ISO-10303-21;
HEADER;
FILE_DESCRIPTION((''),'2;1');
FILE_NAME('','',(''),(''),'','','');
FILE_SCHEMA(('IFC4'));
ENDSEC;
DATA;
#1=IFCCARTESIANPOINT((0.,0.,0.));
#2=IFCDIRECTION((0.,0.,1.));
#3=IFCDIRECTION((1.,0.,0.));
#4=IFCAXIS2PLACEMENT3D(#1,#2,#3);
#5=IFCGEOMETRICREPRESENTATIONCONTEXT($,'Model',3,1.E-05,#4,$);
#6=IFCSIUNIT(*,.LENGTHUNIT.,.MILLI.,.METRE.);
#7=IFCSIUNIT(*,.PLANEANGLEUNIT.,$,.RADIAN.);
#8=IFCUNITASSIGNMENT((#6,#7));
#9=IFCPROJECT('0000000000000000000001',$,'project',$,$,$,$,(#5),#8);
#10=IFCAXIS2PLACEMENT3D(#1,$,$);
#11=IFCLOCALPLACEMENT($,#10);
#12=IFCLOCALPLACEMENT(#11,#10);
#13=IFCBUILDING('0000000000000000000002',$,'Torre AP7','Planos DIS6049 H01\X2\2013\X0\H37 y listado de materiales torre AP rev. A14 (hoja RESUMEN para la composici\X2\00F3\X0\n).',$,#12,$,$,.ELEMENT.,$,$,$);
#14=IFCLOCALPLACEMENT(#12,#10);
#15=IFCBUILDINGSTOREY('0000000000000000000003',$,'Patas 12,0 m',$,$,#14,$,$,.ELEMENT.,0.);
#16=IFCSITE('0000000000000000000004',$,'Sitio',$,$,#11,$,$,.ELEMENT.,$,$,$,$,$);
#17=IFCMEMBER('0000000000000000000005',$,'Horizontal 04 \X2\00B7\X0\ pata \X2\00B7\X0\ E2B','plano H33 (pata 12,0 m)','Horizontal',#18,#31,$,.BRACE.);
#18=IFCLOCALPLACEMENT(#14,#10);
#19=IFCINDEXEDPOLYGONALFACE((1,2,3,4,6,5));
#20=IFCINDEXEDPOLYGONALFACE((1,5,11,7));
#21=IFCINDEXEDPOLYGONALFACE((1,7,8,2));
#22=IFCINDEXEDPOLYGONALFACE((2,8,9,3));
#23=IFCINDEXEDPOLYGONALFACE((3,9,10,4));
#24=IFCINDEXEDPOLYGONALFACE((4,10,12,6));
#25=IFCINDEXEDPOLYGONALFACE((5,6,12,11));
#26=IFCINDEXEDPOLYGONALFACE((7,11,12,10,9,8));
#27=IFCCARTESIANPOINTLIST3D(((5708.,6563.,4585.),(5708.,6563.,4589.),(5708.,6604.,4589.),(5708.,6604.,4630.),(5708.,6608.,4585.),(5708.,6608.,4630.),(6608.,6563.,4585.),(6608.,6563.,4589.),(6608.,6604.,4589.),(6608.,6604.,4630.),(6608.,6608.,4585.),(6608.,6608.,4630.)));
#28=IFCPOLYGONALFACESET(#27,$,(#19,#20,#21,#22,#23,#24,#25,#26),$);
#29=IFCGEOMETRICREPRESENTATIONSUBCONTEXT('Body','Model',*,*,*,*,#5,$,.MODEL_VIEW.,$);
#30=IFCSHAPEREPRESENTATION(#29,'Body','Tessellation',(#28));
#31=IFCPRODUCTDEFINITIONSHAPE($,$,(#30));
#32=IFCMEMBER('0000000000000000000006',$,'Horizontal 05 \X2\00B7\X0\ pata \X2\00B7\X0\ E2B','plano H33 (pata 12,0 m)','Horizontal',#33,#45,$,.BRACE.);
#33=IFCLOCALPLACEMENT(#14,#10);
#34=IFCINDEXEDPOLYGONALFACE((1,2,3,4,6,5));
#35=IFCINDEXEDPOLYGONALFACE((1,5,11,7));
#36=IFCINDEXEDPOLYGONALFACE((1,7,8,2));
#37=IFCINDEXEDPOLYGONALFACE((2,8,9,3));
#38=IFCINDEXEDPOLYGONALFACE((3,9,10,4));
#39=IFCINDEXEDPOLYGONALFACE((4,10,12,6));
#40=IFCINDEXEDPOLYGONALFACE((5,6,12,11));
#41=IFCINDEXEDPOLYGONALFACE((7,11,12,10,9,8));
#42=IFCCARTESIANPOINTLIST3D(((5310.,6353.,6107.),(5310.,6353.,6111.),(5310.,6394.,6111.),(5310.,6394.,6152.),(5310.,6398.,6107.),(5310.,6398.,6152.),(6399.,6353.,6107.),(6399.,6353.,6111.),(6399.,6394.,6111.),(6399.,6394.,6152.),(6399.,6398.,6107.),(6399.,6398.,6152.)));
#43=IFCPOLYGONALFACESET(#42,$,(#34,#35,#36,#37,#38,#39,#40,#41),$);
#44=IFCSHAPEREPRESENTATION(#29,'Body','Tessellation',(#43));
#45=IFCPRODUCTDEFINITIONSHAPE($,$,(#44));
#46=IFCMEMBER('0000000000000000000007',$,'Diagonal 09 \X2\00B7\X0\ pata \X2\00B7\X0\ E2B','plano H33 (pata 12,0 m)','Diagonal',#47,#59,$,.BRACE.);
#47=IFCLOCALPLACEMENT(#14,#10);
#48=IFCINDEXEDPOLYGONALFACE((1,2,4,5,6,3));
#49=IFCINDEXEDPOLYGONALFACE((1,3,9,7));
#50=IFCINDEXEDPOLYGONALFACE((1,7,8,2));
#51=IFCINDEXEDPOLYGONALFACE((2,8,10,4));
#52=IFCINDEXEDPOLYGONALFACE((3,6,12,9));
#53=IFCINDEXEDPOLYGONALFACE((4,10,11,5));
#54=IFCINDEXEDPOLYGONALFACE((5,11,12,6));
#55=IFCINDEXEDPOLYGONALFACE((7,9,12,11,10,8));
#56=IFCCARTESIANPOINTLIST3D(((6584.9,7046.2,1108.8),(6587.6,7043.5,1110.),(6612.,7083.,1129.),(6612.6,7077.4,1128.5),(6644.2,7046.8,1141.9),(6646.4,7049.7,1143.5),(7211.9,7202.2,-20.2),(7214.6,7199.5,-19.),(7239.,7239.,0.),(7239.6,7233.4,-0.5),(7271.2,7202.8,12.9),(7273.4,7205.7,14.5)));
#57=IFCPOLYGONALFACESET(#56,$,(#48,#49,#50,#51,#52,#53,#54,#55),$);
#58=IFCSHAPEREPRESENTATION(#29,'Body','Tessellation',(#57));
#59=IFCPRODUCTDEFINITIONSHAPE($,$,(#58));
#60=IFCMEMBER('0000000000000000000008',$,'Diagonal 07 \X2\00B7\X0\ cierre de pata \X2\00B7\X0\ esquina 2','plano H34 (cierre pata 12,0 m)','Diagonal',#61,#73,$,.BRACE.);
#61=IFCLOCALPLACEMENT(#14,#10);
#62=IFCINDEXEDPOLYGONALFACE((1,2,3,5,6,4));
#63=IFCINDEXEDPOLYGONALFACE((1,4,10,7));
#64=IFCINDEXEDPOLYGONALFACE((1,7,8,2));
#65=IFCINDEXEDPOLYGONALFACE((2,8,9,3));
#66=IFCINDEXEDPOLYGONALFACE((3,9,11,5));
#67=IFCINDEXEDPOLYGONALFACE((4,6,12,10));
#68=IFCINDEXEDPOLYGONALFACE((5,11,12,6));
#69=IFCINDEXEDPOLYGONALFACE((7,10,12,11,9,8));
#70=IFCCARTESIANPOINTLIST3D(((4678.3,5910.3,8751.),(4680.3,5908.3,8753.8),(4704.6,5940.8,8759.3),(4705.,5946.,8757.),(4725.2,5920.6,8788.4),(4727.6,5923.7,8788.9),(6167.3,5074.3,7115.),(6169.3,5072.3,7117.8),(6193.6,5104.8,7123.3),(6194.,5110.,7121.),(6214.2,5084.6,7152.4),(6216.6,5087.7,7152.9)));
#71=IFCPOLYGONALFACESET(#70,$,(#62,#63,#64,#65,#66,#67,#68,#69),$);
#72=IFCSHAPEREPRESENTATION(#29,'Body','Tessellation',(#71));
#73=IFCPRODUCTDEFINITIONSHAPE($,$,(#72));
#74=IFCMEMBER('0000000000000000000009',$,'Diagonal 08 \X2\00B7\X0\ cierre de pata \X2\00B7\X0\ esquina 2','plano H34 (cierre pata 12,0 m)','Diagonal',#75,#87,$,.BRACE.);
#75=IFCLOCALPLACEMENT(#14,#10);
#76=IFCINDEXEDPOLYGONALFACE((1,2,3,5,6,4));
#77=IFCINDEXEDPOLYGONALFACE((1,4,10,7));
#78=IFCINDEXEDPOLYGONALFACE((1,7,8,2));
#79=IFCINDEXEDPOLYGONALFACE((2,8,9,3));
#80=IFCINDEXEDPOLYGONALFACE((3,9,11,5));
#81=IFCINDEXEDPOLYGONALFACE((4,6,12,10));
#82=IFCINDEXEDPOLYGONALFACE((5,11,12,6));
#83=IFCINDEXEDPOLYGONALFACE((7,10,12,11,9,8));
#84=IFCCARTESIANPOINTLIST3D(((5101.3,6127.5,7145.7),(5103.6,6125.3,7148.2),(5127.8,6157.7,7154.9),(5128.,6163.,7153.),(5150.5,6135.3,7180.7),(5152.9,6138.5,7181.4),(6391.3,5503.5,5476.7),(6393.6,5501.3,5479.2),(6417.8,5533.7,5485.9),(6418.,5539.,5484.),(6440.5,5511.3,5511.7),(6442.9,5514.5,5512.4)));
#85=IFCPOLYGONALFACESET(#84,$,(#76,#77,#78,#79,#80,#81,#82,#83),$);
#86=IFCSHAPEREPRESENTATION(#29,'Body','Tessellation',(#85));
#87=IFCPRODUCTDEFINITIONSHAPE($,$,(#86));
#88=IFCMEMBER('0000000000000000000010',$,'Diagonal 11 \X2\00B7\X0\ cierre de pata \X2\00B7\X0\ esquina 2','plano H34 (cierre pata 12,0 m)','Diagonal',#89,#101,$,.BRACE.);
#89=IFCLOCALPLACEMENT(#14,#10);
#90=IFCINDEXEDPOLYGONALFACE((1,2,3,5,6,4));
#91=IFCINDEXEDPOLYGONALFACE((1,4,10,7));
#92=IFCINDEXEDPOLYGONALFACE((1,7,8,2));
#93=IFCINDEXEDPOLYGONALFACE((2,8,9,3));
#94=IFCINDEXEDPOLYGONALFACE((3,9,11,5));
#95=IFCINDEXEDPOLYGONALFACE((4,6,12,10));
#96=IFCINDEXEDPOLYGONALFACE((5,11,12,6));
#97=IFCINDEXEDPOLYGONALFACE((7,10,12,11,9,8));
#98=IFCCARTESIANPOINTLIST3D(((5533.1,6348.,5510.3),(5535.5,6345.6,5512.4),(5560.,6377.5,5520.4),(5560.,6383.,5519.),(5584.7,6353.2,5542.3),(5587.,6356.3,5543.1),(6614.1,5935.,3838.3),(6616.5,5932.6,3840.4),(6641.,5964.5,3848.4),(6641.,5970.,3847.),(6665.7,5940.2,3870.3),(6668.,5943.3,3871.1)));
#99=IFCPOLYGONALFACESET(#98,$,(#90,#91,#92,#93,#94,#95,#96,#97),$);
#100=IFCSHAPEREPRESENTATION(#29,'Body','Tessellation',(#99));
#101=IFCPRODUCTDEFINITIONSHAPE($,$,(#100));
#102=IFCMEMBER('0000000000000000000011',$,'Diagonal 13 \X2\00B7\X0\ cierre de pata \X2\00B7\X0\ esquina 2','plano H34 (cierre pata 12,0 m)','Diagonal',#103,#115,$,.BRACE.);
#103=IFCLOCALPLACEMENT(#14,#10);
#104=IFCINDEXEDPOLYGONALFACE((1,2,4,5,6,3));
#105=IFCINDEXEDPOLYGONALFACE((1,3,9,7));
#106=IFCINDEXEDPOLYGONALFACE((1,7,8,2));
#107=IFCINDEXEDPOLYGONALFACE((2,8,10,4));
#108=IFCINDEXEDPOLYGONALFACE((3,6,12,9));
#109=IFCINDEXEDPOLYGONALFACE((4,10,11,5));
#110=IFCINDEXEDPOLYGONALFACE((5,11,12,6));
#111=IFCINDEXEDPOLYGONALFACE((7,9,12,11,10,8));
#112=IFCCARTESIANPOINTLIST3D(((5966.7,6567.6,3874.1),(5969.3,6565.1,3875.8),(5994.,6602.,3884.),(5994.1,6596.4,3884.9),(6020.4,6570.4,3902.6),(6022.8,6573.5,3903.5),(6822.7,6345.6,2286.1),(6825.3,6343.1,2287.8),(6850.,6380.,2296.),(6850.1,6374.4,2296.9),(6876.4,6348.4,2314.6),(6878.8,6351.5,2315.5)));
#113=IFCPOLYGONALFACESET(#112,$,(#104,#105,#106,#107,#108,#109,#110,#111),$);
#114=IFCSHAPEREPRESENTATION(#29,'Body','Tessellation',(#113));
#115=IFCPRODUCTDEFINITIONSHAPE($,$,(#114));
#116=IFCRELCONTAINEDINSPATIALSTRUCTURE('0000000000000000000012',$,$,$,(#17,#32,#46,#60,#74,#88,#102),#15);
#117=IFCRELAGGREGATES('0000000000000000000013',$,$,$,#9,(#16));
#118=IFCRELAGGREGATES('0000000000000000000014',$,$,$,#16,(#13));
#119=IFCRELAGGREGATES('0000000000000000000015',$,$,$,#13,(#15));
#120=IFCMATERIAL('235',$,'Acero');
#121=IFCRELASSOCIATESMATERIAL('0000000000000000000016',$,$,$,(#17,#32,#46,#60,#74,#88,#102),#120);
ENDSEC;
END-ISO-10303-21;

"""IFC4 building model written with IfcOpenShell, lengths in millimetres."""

from ifc_helpers import new_model, si_unit, frame, frame_2d, origin, origin_with_axes, place, context, subcontext, project, spatial, l_section, extrude, material, element, save


model = new_model("IFC4")

# Units and contexts
model_context = context("Model", 3, precision=1e-05, world=origin_with_axes())
body_context = subcontext(model_context, "Body", "Model", "MODEL_VIEW")
ifc_project = project(units=[si_unit("LENGTHUNIT", "METRE", prefix="MILLI"), si_unit("PLANEANGLEUNIT", "RADIAN")], contexts=[model_context])

# Site, building, storey
site_placement = place(None, origin())
site = spatial("IfcSite", under=ifc_project, at=site_placement, Name="Sitio", CompositionType="ELEMENT")
building_placement = place(site_placement, origin())
building = spatial("IfcBuilding", under=site, at=building_placement, Name="Torre AP7", Description="Planos DIS6049 H01–H37 y listado de materiales torre AP rev. A14 (hoja RESUMEN para la composición).", CompositionType="ELEMENT")
storey_placement = place(building_placement, origin())
storey = spatial("IfcBuildingStorey", under=building, at=storey_placement, Name="Patas 12,0 m", CompositionType="ELEMENT", Elevation=0.0)

# Members
ifc_material_1 = material(Name="235", Category="Acero")
member_1_placement = place(storey_placement, frame((6608.0, 6608.0, 4585.0), z_axis=(-1.0, 0.0, 0.0), x_axis=(0.0, -1.0, 0.0)))
element("IfcMember", 1, at=member_1_placement, inside=storey, material=ifc_material_1, Name="Horizontal 04 · pata · E2B", Description="plano H33 (pata 12,0 m)", ObjectType="Horizontal", PredefinedType="BRACE", context=body_context, shape_type="SweptSolid", body=[
    extrude(l_section(Depth=45.0, Width=45.0, Thickness=4.0, at=frame_2d((22.5, 22.5))), None, (0.0, 0.0, 1.0), 900.0),
])
member_2_placement = place(storey_placement, frame((6399.0, 6398.0, 6107.0), z_axis=(-1.0, 0.0, 0.0), x_axis=(0.0, -1.0, 0.0)))
element("IfcMember", 2, at=member_2_placement, inside=storey, material=ifc_material_1, Name="Horizontal 05 · pata · E2B", Description="plano H33 (pata 12,0 m)", ObjectType="Horizontal", PredefinedType="BRACE", context=body_context, shape_type="SweptSolid", body=[
    extrude(l_section(Depth=45.0, Width=45.0, Thickness=4.0, at=frame_2d((22.5, 22.5))), None, (0.0, 0.0, 1.0), 1089.0),
])
member_3_placement = place(storey_placement, frame((7239.0, 7239.0, 0.0), z_axis=(-0.482007, -0.119925, 0.867921), x_axis=(-0.542627, -0.73689, -0.403173)))
element("IfcMember", 3, at=member_3_placement, inside=storey, material=ifc_material_1, Name="Diagonal 09 · pata · E2B", Description="plano H33 (pata 12,0 m)", ObjectType="Diagonal", PredefinedType="BRACE", context=body_context, shape_type="SweptSolid", body=[
    extrude(l_section(Depth=50.0, Width=50.0, Thickness=4.0, at=frame_2d((25.0, 25.0))), None, (0.0, 0.0, 1.0), 1300.8),
])
member_4_placement = place(storey_placement, frame((6194.0, 5110.0, 7121.0), z_axis=(-0.629638, 0.353511, 0.691799), x_axis=(-0.593062, -0.793914, -0.134082)))
element("IfcMember", 4, at=member_4_placement, inside=storey, material=ifc_material_1, Name="Diagonal 07 · cierre de pata · esquina 2", Description="plano H34 (cierre pata 12,0 m)", ObjectType="Diagonal", PredefinedType="BRACE", context=body_context, shape_type="SweptSolid", body=[
    extrude(l_section(Depth=45.0, Width=45.0, Thickness=4.0, at=frame_2d((22.5, 22.5))), None, (0.0, 0.0, 1.0), 2364.8),
])
member_5_placement = place(storey_placement, frame((6418.0, 5539.0, 5484.0), z_axis=(-0.586422, 0.283665, 0.758712), x_axis=(-0.592431, -0.788975, -0.162922)))
element("IfcMember", 5, at=member_5_placement, inside=storey, material=ifc_material_1, Name="Diagonal 08 · cierre de pata · esquina 2", Description="plano H34 (cierre pata 12,0 m)", ObjectType="Diagonal", PredefinedType="BRACE", context=body_context, shape_type="SweptSolid", body=[
    extrude(l_section(Depth=45.0, Width=45.0, Thickness=4.0, at=frame_2d((22.5, 22.5))), None, (0.0, 0.0, 1.0), 2199.8),
])
member_6_placement = place(storey_placement, frame((6641.0, 5970.0, 3847.0), z_axis=(-0.531622, 0.203108, 0.822268), x_axis=(-0.596805, -0.778704, -0.193506)))
element("IfcMember", 6, at=member_6_placement, inside=storey, material=ifc_material_1, Name="Diagonal 11 · cierre de pata · esquina 2", Description="plano H34 (cierre pata 12,0 m)", ObjectType="Diagonal", PredefinedType="BRACE", context=body_context, shape_type="SweptSolid", body=[
    extrude(l_section(Depth=45.0, Width=45.0, Thickness=4.0, at=frame_2d((22.5, 22.5))), None, (0.0, 0.0, 1.0), 2033.4),
])
member_7_placement = place(storey_placement, frame((6850.0, 6380.0, 2296.0), z_axis=(-0.470944, 0.122137, 0.873667), x_axis=(-0.606616, -0.76389, -0.220201)))
element("IfcMember", 7, at=member_7_placement, inside=storey, material=ifc_material_1, Name="Diagonal 13 · cierre de pata · esquina 2", Description="plano H34 (cierre pata 12,0 m)", ObjectType="Diagonal", PredefinedType="BRACE", context=body_context, shape_type="SweptSolid", body=[
    extrude(l_section(Depth=45.0, Width=45.0, Thickness=4.0, at=frame_2d((22.5, 22.5))), None, (0.0, 0.0, 1.0), 1817.6),
])

save(model, "model.ifc")
